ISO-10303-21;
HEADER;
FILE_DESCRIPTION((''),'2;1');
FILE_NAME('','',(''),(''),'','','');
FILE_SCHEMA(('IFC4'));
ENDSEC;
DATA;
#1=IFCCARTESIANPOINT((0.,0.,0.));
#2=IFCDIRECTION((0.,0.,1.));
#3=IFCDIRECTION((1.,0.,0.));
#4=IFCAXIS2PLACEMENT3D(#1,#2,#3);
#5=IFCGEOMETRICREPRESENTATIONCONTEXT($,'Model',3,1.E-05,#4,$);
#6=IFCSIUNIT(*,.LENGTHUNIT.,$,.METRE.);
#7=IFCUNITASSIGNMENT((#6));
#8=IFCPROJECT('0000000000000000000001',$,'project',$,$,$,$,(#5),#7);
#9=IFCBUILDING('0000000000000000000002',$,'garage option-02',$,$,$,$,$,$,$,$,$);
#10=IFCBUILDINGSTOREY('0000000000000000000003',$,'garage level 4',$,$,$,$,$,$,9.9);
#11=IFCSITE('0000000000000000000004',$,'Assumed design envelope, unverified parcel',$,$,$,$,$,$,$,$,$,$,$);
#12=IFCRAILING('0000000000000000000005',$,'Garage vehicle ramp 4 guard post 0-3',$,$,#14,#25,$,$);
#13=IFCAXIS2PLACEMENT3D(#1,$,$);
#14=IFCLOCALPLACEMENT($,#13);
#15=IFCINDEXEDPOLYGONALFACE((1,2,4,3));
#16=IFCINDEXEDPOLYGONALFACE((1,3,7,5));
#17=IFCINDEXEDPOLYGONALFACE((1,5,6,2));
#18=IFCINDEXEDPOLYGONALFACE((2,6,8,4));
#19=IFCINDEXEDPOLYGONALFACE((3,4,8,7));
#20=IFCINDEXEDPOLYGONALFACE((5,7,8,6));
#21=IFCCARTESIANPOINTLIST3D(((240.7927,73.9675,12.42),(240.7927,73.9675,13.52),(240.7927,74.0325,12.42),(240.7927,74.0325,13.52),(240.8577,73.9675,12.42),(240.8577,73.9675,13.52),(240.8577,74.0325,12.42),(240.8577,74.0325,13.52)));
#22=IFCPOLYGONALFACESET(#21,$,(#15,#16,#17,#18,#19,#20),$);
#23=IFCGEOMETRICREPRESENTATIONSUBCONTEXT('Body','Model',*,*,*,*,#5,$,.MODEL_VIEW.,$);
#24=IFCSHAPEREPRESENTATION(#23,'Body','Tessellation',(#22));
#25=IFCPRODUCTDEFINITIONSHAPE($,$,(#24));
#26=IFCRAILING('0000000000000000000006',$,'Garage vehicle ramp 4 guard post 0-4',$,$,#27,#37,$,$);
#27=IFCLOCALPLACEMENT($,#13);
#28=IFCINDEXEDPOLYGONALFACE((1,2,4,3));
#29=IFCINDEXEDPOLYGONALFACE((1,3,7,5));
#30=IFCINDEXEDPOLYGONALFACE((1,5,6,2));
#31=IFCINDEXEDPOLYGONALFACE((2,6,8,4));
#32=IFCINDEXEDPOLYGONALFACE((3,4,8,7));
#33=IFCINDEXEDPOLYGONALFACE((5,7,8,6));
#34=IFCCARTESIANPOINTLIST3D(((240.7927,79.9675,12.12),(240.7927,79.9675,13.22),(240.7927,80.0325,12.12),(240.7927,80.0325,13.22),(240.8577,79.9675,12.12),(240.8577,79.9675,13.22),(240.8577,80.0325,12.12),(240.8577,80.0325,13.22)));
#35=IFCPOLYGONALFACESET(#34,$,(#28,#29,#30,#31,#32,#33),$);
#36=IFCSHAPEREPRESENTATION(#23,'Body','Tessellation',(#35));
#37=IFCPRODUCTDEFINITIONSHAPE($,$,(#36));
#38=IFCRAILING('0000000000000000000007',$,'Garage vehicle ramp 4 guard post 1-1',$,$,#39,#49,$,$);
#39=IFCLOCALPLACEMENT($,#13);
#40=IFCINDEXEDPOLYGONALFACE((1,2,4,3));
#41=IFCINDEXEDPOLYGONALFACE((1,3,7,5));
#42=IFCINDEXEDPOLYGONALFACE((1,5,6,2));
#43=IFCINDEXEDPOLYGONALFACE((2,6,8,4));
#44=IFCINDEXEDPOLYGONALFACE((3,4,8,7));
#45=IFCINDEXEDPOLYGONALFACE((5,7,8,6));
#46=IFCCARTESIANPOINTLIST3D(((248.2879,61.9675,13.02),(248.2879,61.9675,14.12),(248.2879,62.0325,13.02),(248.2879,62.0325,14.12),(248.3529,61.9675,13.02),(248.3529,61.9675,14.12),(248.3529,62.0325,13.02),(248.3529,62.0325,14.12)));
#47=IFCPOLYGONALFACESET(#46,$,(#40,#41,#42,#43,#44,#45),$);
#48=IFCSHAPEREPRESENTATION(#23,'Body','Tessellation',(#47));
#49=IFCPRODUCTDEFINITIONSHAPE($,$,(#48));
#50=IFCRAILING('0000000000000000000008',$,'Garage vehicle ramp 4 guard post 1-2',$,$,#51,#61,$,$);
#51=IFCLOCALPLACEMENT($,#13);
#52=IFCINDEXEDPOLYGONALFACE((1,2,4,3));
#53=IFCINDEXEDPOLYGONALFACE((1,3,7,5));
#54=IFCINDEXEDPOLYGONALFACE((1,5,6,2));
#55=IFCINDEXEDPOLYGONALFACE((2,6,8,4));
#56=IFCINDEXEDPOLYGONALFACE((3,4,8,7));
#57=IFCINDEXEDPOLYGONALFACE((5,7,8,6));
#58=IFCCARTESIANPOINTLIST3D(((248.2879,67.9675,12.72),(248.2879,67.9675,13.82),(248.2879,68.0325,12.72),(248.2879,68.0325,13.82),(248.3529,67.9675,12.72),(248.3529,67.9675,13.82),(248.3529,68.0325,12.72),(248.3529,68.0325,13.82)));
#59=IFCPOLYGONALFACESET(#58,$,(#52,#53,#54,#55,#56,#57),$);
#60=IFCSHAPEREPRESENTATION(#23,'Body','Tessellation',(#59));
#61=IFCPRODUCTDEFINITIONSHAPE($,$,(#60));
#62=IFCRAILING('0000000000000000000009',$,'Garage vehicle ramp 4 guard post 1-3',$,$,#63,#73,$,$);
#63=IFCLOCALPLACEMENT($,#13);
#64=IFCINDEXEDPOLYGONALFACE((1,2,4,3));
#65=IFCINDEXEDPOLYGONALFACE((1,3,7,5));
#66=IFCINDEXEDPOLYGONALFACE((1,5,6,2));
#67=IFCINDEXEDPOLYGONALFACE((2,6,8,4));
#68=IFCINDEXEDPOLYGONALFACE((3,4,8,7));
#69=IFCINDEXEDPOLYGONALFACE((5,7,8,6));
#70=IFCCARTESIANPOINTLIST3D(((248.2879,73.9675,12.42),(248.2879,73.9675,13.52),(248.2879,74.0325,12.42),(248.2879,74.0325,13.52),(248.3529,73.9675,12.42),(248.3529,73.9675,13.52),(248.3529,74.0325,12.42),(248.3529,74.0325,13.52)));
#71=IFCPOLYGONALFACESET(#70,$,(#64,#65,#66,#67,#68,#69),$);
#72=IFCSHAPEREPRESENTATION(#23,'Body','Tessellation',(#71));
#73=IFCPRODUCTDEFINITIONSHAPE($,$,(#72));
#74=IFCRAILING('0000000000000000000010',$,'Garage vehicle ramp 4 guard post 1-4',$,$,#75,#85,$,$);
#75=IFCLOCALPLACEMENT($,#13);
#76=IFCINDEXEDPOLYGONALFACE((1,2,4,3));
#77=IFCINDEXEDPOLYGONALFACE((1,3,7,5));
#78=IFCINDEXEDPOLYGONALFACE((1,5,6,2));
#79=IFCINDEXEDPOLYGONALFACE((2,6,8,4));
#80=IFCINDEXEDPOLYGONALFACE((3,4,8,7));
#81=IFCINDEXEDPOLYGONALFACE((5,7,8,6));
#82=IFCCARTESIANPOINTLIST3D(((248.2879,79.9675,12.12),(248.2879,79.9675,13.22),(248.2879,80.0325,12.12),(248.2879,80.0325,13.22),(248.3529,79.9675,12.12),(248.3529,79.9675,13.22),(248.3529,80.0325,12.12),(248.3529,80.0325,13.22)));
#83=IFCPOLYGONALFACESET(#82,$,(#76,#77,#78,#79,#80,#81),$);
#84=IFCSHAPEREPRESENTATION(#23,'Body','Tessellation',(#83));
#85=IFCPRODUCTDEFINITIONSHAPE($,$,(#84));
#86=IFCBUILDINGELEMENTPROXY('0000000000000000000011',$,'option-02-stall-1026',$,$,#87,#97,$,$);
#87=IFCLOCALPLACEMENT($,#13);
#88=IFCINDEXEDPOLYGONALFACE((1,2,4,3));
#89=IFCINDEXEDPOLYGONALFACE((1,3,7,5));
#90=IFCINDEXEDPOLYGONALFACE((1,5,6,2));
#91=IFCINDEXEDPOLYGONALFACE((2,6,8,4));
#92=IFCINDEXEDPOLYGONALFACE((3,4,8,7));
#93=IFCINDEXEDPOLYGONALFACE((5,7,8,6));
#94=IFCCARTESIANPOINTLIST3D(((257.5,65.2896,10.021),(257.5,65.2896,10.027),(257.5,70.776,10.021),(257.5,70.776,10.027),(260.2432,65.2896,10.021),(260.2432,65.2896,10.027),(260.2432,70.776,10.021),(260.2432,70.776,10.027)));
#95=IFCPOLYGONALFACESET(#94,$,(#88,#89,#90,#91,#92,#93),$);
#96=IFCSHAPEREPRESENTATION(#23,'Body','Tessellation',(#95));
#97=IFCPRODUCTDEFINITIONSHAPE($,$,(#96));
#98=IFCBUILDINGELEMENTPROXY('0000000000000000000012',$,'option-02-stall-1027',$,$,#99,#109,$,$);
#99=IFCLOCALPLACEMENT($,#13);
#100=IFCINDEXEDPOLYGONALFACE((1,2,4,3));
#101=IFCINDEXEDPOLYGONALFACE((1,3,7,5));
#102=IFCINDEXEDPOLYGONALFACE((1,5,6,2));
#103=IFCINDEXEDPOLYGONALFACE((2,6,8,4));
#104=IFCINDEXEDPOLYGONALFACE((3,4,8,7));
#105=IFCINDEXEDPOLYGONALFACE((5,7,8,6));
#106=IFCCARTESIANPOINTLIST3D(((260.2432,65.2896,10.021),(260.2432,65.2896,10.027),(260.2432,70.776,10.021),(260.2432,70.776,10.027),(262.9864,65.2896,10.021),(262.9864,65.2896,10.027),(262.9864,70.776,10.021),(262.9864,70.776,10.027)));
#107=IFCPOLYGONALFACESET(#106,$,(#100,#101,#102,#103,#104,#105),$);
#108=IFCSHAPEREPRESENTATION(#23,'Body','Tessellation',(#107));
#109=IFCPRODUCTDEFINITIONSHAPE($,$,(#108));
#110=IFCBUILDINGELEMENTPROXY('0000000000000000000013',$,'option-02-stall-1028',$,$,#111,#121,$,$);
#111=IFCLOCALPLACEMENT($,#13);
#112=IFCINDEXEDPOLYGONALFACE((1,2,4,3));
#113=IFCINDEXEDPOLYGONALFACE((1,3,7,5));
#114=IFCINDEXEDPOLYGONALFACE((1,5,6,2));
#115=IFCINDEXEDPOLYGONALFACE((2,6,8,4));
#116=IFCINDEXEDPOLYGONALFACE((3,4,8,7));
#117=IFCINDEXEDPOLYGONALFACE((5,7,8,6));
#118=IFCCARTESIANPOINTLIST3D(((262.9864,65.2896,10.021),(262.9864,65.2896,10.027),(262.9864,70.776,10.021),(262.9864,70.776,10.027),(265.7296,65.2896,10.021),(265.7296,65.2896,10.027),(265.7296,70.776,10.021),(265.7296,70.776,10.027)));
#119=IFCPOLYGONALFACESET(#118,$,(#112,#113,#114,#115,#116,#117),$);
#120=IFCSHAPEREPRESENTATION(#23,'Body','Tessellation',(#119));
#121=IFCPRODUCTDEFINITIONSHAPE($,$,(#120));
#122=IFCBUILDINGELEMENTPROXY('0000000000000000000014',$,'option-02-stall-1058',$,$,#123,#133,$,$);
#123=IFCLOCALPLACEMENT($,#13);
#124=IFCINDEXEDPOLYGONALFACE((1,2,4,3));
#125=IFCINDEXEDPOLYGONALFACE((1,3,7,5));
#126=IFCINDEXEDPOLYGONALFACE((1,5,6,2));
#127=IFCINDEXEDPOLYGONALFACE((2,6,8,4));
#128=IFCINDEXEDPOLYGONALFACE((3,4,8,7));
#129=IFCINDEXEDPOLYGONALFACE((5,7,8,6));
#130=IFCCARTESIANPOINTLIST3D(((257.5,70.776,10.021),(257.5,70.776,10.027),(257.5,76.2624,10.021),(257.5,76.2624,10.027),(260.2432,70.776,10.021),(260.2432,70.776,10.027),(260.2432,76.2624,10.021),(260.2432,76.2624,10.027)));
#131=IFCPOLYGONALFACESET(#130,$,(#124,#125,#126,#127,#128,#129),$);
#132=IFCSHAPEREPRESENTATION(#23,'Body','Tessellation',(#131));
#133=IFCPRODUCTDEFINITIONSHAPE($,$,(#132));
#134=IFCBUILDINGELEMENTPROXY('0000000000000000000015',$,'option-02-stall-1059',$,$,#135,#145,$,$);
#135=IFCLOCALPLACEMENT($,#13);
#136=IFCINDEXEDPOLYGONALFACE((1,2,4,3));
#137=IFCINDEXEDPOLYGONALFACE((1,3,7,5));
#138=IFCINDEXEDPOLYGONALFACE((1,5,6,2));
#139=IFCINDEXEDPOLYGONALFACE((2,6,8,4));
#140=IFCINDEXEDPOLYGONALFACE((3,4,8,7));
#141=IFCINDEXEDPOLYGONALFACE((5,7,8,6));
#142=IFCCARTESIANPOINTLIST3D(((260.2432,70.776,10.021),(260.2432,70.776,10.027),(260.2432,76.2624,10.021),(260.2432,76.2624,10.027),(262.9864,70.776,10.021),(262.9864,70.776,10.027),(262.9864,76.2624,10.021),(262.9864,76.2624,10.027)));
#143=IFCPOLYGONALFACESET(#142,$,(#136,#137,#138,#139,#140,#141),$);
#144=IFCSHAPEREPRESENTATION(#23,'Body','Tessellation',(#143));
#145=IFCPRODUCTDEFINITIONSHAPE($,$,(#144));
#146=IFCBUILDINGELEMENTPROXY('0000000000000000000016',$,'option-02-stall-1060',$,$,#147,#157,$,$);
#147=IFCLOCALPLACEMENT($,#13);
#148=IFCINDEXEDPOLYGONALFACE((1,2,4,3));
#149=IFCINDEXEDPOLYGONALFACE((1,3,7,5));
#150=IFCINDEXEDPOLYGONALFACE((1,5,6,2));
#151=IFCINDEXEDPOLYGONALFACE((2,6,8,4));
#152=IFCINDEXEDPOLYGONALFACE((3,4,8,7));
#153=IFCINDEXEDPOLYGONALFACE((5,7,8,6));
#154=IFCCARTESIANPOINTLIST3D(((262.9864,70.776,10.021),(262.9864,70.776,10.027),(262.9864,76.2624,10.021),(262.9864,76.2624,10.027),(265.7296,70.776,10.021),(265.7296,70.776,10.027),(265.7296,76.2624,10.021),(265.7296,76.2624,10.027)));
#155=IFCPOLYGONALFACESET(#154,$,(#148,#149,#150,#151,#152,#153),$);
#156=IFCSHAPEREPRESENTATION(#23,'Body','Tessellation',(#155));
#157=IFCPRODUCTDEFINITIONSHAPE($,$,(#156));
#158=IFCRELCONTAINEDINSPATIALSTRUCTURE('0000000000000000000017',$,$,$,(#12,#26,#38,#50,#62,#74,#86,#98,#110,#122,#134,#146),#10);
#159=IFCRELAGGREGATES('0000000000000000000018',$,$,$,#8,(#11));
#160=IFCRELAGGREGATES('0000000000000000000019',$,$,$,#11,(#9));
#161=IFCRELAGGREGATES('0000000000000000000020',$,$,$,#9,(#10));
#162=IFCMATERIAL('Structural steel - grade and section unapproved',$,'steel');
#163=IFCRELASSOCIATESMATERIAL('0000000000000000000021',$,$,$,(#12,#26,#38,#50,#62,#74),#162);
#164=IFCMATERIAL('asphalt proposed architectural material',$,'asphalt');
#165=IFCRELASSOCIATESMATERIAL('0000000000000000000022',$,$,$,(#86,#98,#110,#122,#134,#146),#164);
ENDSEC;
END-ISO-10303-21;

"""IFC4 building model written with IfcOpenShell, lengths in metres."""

from ifc_helpers import new_model, si_unit, frame, origin_with_axes, place, context, subcontext, project, spatial, rectangle, extrude, material, element, save


model = new_model("IFC4")

# Units and contexts
model_context = context("Model", 3, precision=1e-05, world=origin_with_axes())
body_context = subcontext(model_context, "Body", "Model", "MODEL_VIEW")
ifc_project = project(units=[si_unit("LENGTHUNIT", "METRE")], contexts=[model_context])

# Site, building, storey
site = spatial("IfcSite", under=ifc_project, Name="Assumed design envelope, unverified parcel")
building = spatial("IfcBuilding", under=site, Name="garage option-02")
storey = spatial("IfcBuildingStorey", under=building, Name="garage level 4", Elevation=9.9)

# Shared definitions
ifc_material_1 = material(Name="Structural steel - grade and section unapproved", Category="steel")

# Railings
for number, where, z_axis, x_axis, name in (
    (1, (240.8252, 74.0, 12.42), (0.0, 0.0, 1.0), (-1.0, 0.0, 0.0), "Garage vehicle ramp 4 guard post 0-3"),
    (2, (240.8252, 80.0, 12.12), (0.0, 0.0, 1.0), (-1.0, 0.0, 0.0), "Garage vehicle ramp 4 guard post 0-4"),
):
    element("IfcRailing", number, at=place(None, frame(where, z_axis=z_axis, x_axis=x_axis)), inside=storey, material=ifc_material_1, Name=name, context=body_context, shape_type="SweptSolid", body=[
        extrude(rectangle(XDim=0.065, YDim=0.065), origin_with_axes(), (0.0, 0.0, 1.0), 1.1),
    ])
for number, where, z_axis, x_axis, name in (
    (3, (248.3204, 62.0, 13.02), (0.0, 0.0, 1.0), (-1.0, 0.0, 0.0), "Garage vehicle ramp 4 guard post 1-1"),
    (4, (248.3204, 68.0, 12.72), (0.0, 0.0, 1.0), (-1.0, 0.0, 0.0), "Garage vehicle ramp 4 guard post 1-2"),
):
    element("IfcRailing", number, at=place(None, frame(where, z_axis=z_axis, x_axis=x_axis)), inside=storey, material=ifc_material_1, Name=name, context=body_context, shape_type="SweptSolid", body=[
        extrude(rectangle(XDim=0.065, YDim=0.065), origin_with_axes(), (0.0, 0.0, 1.0), 1.1),
    ])
for number, where, z_axis, x_axis, name in (
    (5, (248.3204, 74.0, 12.42), (0.0, 0.0, 1.0), (-1.0, 0.0, 0.0), "Garage vehicle ramp 4 guard post 1-3"),
    (6, (248.3204, 80.0, 12.12), (0.0, 0.0, 1.0), (-1.0, 0.0, 0.0), "Garage vehicle ramp 4 guard post 1-4"),
):
    element("IfcRailing", number, at=place(None, frame(where, z_axis=z_axis, x_axis=x_axis)), inside=storey, material=ifc_material_1, Name=name, context=body_context, shape_type="SweptSolid", body=[
        extrude(rectangle(XDim=0.065, YDim=0.065), origin_with_axes(), (0.0, 0.0, 1.0), 1.1),
    ])

# Building element proxies
ifc_material_2 = material(Name="asphalt proposed architectural material", Category="asphalt")
for number, where, z_axis, x_axis, name in (
    (7, (258.8716, 68.0328, 10.021), (0.0, 0.0, 1.0), (1.0, 0.0, 0.0), "option-02-stall-1026"),
    (8, (261.6148, 68.0328, 10.021), (0.0, 0.0, 1.0), (1.0, 0.0, 0.0), "option-02-stall-1027"),
    (9, (264.358, 68.0328, 10.021), (0.0, 0.0, 1.0), (1.0, 0.0, 0.0), "option-02-stall-1028"),
    (10, (258.8716, 73.5192, 10.021), (0.0, 0.0, 1.0), (1.0, 0.0, 0.0), "option-02-stall-1058"),
    (11, (261.6148, 73.5192, 10.021), (0.0, 0.0, 1.0), (1.0, 0.0, 0.0), "option-02-stall-1059"),
    (12, (264.358, 73.5192, 10.021), (0.0, 0.0, 1.0), (1.0, 0.0, 0.0), "option-02-stall-1060"),
):
    element("IfcBuildingElementProxy", number, at=place(None, frame(where, z_axis=z_axis, x_axis=x_axis)), inside=storey, material=ifc_material_2, Name=name, context=body_context, shape_type="SweptSolid", body=[
        extrude(rectangle(XDim=2.7432, YDim=5.4864), origin_with_axes(), (0.0, 0.0, 1.0), 0.006),
    ])

save(model, "model.ifc")
